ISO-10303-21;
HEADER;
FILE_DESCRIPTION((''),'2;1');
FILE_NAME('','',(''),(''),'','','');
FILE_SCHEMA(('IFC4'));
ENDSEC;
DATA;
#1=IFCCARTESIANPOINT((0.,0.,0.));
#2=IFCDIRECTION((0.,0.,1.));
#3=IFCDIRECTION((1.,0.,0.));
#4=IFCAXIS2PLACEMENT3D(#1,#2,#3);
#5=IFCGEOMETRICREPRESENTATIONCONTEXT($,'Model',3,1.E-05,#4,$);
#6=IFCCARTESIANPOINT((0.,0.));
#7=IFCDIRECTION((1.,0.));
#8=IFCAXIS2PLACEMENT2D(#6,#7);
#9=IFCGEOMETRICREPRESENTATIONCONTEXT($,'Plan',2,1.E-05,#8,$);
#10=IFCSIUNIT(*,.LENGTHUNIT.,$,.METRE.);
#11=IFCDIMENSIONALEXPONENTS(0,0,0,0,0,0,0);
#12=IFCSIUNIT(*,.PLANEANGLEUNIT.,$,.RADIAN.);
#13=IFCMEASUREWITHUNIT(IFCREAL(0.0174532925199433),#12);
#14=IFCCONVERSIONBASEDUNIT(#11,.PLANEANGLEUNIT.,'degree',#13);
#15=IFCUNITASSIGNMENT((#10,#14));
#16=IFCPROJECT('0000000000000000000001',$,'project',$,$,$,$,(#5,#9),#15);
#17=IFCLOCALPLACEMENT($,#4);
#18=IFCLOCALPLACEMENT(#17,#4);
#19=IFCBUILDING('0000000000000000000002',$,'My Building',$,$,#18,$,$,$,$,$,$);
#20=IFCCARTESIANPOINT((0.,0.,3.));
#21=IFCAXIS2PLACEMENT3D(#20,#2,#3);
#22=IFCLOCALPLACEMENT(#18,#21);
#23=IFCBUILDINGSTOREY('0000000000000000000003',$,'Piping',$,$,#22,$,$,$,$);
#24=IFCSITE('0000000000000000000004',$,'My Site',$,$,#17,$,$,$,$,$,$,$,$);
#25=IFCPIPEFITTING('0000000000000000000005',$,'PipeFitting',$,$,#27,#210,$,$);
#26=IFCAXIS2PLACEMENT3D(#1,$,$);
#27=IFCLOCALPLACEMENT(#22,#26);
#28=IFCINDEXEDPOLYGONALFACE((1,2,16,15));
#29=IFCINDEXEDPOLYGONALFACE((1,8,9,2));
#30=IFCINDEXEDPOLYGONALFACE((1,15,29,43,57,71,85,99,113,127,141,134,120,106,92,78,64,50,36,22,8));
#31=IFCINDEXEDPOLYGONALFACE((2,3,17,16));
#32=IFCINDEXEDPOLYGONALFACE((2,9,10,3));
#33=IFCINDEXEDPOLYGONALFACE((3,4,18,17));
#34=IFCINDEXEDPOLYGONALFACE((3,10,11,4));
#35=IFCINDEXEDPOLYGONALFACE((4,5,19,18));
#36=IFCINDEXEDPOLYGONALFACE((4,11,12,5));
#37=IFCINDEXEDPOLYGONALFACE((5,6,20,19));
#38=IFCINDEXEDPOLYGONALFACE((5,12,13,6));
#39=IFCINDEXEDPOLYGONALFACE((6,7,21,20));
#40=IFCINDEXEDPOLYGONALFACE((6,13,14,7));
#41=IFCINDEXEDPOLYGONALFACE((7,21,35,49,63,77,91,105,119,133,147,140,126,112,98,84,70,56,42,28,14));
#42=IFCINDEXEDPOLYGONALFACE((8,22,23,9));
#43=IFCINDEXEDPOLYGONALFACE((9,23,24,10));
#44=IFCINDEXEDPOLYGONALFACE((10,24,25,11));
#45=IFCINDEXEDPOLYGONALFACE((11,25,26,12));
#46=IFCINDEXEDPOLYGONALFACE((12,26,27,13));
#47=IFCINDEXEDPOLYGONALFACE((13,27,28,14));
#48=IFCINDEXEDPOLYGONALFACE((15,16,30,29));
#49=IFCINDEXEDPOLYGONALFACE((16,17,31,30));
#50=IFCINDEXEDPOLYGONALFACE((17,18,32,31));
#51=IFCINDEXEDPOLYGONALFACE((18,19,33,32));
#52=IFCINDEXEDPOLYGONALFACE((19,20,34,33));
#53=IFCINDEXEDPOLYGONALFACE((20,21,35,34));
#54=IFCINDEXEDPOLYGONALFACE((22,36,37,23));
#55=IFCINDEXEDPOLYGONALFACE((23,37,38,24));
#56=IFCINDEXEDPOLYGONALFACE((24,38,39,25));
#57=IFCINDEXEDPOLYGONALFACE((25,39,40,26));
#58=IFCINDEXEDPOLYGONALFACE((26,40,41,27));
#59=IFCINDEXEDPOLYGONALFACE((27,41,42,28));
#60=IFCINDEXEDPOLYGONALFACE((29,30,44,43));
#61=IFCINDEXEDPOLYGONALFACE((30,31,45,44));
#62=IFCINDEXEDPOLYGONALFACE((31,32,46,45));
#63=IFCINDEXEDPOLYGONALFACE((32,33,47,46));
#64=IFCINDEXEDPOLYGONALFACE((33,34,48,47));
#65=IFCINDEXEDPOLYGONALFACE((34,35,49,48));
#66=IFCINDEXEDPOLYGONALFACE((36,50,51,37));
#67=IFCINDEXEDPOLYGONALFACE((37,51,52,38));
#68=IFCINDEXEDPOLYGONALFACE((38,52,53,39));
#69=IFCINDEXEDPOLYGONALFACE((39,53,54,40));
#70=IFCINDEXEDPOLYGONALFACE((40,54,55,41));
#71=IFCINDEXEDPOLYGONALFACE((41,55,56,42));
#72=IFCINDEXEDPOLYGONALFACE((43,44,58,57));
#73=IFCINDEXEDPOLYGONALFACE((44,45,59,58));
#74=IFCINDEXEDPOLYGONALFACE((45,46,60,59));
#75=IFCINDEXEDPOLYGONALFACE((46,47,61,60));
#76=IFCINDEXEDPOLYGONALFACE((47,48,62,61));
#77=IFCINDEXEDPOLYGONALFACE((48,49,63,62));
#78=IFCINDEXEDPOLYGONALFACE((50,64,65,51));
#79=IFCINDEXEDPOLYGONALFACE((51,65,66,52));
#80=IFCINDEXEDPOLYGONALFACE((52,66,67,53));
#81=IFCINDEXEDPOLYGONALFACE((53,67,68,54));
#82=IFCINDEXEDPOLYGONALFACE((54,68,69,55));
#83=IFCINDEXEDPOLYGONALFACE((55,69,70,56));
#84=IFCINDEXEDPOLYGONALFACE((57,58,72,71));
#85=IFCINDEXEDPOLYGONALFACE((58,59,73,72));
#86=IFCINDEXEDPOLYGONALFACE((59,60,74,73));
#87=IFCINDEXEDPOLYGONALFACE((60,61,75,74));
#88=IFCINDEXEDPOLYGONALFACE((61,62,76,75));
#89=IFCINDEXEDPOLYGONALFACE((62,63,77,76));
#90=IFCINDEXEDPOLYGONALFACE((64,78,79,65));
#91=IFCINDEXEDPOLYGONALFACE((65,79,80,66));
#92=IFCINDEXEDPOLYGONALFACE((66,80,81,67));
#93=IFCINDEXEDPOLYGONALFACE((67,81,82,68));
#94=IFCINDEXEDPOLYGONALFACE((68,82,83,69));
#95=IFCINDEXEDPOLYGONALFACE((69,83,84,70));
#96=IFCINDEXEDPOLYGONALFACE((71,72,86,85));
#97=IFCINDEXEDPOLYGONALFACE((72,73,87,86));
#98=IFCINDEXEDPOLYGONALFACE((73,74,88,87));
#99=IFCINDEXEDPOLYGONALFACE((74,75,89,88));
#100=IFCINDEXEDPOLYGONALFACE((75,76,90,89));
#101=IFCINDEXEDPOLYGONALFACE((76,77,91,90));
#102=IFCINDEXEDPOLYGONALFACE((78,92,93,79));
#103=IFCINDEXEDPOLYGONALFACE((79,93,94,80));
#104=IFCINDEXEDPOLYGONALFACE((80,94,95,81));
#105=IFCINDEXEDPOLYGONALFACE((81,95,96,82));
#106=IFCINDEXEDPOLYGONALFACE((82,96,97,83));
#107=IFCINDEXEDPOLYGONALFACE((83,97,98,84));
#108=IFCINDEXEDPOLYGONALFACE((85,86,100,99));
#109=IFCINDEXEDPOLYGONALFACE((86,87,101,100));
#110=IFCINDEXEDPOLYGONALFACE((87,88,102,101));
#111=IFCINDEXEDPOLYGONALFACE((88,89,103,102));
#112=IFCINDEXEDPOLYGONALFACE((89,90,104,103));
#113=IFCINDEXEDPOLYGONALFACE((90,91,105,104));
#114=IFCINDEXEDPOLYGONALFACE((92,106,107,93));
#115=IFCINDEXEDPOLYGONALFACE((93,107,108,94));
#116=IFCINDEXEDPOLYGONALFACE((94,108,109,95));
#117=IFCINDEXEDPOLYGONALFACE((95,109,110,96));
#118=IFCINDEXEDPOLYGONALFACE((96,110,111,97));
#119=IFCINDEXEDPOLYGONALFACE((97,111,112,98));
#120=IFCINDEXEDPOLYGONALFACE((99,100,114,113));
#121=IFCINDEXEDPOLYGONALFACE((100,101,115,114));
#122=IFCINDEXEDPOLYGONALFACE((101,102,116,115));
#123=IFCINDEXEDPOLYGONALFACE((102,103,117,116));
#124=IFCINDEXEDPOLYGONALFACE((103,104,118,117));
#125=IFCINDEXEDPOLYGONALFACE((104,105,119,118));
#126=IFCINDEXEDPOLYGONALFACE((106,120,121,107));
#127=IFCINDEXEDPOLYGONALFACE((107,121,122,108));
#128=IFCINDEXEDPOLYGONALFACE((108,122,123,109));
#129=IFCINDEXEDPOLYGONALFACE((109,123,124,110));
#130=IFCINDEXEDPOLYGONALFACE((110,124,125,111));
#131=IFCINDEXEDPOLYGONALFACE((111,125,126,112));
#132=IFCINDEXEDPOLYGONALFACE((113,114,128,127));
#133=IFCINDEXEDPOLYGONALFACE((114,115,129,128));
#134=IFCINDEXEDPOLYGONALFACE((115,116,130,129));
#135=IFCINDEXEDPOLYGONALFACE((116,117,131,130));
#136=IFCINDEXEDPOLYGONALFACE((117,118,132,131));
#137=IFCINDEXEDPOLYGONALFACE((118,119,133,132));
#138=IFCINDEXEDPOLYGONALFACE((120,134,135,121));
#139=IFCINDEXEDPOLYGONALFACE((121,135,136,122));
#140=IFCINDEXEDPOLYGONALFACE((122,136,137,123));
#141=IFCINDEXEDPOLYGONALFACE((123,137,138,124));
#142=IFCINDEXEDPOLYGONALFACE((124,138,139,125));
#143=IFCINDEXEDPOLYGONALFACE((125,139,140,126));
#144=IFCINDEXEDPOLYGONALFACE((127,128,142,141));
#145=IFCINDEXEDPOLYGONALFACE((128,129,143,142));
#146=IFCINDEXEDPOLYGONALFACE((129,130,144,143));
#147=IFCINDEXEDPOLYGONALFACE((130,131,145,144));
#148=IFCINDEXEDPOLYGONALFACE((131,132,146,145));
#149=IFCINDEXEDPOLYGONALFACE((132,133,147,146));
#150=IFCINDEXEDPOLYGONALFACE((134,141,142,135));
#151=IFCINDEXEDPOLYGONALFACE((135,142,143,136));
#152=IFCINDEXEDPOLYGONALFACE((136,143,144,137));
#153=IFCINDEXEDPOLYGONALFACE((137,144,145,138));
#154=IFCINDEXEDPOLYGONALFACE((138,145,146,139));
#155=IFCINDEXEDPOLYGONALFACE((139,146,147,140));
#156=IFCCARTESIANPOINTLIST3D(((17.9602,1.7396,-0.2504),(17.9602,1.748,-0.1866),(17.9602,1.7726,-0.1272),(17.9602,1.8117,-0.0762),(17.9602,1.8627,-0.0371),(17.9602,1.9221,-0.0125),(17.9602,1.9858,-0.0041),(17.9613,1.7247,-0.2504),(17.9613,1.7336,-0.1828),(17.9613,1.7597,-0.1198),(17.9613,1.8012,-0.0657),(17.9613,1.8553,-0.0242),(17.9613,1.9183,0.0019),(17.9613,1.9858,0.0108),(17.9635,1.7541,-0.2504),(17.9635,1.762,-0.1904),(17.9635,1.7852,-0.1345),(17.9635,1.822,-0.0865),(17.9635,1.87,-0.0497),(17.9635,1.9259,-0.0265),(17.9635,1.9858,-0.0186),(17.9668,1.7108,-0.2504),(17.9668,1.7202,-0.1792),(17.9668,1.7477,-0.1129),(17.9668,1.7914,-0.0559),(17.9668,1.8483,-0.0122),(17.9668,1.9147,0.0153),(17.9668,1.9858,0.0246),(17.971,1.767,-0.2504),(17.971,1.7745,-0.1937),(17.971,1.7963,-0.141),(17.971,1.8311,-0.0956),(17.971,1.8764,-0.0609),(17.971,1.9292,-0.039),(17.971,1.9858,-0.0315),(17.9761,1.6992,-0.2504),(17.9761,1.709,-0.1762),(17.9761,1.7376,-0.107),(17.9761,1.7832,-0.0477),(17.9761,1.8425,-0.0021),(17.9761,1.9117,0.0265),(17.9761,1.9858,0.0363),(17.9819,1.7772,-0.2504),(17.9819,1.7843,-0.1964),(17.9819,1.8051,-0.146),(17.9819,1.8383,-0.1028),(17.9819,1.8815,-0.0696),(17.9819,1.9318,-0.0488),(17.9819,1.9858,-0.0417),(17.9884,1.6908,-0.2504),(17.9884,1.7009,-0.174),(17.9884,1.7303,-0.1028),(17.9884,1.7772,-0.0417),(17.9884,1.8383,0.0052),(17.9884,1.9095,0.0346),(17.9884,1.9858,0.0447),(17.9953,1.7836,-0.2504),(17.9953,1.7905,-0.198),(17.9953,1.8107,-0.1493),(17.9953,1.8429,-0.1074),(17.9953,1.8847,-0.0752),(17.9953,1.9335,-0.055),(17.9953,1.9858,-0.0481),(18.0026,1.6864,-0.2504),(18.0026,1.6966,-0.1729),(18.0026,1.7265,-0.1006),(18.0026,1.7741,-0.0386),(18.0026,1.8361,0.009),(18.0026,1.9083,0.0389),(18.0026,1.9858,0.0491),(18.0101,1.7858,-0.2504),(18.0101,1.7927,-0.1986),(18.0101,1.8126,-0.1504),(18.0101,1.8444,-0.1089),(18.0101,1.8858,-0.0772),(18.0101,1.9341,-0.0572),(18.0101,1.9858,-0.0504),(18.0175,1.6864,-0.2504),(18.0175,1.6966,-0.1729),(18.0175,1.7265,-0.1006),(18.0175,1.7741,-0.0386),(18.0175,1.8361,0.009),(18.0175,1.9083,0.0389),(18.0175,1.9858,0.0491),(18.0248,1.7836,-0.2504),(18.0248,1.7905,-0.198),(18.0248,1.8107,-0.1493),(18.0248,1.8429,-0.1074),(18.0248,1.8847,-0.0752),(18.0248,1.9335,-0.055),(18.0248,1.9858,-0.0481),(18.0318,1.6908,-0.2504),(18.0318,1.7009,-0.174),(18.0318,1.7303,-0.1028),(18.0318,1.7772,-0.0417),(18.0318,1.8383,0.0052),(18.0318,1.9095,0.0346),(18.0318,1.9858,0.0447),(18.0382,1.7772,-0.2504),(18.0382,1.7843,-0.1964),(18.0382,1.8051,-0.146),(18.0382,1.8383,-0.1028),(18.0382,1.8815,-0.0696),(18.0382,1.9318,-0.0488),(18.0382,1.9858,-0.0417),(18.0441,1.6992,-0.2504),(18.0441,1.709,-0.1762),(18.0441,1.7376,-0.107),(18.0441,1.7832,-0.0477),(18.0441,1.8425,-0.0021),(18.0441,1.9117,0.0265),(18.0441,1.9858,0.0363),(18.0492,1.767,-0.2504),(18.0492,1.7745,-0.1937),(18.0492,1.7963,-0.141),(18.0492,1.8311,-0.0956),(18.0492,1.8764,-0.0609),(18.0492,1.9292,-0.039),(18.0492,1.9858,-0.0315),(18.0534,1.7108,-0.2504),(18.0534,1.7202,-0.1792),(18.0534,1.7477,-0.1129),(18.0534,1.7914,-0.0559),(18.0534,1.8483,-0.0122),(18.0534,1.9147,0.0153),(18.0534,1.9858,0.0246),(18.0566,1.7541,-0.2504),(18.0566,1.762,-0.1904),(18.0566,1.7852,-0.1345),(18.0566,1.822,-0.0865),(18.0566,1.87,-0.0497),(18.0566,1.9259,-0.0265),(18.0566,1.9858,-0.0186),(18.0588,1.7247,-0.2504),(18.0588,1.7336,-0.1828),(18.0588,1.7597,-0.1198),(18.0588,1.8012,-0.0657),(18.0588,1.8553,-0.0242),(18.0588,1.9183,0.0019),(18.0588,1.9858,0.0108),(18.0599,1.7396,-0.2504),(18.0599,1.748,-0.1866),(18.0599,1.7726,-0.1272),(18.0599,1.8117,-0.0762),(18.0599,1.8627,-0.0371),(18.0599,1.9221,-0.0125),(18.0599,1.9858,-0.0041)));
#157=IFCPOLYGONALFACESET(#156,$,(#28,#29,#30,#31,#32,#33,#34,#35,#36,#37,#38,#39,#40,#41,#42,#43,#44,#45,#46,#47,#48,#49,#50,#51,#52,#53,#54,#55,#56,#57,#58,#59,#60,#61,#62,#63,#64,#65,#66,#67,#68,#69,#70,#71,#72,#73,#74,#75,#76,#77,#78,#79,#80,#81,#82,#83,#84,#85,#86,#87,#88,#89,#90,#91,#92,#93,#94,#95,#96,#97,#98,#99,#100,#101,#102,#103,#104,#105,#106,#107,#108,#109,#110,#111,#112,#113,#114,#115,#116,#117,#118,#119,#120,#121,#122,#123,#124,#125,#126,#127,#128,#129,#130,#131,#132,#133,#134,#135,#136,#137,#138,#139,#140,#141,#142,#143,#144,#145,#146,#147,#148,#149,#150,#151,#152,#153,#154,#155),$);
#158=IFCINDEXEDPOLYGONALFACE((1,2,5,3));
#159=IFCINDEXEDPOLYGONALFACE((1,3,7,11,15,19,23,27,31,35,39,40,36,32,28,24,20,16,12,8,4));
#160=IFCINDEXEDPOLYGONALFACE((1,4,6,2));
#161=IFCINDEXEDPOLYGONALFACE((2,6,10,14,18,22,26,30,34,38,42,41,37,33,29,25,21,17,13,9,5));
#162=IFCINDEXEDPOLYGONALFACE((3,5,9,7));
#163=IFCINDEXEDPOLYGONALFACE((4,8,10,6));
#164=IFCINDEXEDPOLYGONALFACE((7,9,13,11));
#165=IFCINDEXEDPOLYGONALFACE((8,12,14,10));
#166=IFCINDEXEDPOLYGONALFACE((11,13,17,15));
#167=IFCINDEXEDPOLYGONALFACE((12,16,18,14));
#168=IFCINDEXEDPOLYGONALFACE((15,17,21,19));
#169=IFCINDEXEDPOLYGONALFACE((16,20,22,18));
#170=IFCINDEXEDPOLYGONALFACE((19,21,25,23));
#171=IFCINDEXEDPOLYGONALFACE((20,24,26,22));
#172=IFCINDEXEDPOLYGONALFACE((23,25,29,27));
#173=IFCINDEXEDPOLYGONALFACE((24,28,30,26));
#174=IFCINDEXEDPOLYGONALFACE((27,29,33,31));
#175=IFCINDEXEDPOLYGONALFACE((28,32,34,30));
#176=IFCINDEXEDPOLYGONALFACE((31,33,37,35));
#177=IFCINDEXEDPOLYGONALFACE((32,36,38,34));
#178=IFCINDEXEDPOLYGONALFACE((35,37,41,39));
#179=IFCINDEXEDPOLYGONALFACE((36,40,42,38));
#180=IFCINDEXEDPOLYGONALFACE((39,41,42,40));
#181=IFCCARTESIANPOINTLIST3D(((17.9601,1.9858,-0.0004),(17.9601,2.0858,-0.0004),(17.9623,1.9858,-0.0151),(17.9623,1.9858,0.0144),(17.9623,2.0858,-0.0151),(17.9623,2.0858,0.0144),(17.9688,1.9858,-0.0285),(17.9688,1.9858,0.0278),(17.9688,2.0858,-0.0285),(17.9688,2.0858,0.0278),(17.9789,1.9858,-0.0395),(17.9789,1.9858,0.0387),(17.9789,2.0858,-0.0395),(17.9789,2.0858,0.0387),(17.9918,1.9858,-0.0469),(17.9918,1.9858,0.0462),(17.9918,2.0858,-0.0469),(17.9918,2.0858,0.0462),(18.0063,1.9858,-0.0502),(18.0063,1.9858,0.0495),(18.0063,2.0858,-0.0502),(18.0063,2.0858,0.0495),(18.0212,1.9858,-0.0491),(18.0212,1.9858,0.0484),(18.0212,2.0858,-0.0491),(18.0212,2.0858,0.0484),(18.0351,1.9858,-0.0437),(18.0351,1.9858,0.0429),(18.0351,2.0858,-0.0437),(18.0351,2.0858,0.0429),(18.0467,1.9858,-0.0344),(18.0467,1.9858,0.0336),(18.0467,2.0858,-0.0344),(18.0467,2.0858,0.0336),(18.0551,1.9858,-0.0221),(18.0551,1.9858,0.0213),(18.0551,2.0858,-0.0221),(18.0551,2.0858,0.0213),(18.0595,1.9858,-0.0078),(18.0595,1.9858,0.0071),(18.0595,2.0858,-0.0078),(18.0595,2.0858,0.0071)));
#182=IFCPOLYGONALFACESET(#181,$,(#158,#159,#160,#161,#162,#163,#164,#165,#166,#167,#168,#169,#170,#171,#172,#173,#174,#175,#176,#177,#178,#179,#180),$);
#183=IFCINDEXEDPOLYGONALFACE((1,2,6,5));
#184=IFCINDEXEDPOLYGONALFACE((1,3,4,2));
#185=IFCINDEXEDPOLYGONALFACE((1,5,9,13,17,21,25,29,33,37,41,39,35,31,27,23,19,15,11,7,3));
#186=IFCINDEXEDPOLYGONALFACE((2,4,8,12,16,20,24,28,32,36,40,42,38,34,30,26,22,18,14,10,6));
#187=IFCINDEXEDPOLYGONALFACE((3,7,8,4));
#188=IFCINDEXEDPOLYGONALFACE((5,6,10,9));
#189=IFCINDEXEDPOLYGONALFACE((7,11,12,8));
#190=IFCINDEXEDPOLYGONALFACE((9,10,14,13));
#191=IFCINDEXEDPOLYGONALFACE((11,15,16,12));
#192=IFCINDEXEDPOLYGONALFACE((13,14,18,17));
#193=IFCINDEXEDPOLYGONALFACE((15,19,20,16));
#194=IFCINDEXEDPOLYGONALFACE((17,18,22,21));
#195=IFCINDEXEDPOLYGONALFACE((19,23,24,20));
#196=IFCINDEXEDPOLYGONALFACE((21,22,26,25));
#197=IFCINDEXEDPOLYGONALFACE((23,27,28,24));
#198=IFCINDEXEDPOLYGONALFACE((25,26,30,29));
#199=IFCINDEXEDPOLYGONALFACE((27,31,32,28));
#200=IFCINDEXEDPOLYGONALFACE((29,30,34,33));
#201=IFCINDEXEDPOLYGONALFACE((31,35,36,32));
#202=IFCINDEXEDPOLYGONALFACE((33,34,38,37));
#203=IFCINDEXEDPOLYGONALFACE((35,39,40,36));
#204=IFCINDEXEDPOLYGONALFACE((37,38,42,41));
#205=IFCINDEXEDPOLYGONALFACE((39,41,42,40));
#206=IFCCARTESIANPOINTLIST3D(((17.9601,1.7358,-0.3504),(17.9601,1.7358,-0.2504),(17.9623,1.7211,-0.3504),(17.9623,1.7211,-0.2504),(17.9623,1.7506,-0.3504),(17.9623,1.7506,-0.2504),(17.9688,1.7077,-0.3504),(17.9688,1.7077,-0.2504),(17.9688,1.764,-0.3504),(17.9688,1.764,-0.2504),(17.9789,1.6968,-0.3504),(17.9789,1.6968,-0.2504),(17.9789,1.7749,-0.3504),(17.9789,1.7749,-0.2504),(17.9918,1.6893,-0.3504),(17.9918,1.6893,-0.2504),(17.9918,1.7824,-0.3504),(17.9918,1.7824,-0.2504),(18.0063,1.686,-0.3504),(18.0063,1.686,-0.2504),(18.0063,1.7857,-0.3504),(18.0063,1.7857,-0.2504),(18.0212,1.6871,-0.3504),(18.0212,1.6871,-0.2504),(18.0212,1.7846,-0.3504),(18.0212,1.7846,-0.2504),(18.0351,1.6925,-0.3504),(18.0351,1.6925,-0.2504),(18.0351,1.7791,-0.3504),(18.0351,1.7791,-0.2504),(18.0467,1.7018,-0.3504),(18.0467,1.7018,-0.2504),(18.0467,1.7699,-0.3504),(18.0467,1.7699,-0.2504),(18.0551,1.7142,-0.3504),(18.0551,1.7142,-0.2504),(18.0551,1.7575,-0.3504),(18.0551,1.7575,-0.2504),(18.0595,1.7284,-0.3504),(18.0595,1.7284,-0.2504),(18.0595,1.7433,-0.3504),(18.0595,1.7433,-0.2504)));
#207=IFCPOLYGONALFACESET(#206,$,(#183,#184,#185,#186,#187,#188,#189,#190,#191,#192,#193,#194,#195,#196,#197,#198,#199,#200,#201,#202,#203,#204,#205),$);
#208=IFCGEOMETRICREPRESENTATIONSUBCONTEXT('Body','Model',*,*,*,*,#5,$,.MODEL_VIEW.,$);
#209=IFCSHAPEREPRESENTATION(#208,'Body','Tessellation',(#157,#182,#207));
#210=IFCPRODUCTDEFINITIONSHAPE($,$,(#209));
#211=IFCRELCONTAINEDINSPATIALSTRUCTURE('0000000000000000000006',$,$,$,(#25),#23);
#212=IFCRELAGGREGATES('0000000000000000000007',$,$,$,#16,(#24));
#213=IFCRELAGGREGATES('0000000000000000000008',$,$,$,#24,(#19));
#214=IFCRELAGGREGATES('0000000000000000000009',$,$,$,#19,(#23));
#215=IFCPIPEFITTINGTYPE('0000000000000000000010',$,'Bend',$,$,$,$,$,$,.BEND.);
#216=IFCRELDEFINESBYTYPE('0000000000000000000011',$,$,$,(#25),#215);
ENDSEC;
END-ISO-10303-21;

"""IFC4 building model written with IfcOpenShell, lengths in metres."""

from ifc_helpers import new_model, entity, si_unit, converted_unit, frame, origin_with_axes, origin_2d_with_axis, place, context, subcontext, project, spatial, circle, extrude, source, transform, mapped, type_object, type_shapes, element, save


model = new_model("IFC4")

# Units and contexts
model_context = context("Model", 3, precision=1e-05, world=origin_with_axes())
plan_context = context("Plan", 2, precision=1e-05, world=origin_2d_with_axis())
body_context = subcontext(model_context, "Body", "Model", "MODEL_VIEW")
ifc_project = project(units=[si_unit("LENGTHUNIT", "METRE"), converted_unit("PLANEANGLEUNIT", "degree", entity("IfcReal", 0.0174532925199433), si_unit("PLANEANGLEUNIT", "RADIAN"), dimensions=[0, 0, 0, 0, 0, 0, 0])], contexts=[model_context, plan_context])

# Site, building, storey
site_placement = place(None, origin_with_axes())
site = spatial("IfcSite", under=ifc_project, at=site_placement, Name="My Site")
building_placement = place(site_placement, origin_with_axes())
building = spatial("IfcBuilding", under=site, at=building_placement, Name="My Building")
storey_placement = place(building_placement, frame((0.0, 0.0, 3.0), z_axis=(0.0, 0.0, 1.0), x_axis=(1.0, 0.0, 0.0)))
storey = spatial("IfcBuildingStorey", under=building, at=storey_placement, Name="Piping")

# Shared definitions
pipe_fitting_type = type_object("IfcPipeFittingType", Name="Bend", PredefinedType="BEND")
shared_shape = source(origin_with_axes(), body_context, "Body", "SolidModel", [
    entity("IfcSweptDiskSolid", entity("IfcIndexedPolyCurve", entity("IfcCartesianPointList3D", [[0.0, 0.0, -0.1], [0.0, -0.0732, -0.2768], [0.0, -0.25, -0.35]]), [entity("IfcArcIndex", [1, 2, 3])]), 0.05),
    extrude(circle(Radius=0.05), origin_with_axes(), (0.0, 0.0, -1.0), 0.1),
    extrude(circle(Radius=0.05), frame((0.0, -0.25, -0.35), z_axis=(0.0, -1.0, 0.0), x_axis=(1.0, 0.0, 0.0)), (0.0, 0.0, 1.0), 0.1),
])
type_shapes(pipe_fitting_type, [shared_shape])

# Pipe fitting
for number, where, z_axis, x_axis, name in (
    (1, (18.0101, 2.0858, -0.0004), (0.0, 1.0, 0.0), (-1.0, 0.0, 0.0), "PipeFitting"),
):
    element("IfcPipeFitting", number, at=place(storey_placement, frame(where, z_axis=z_axis, x_axis=x_axis)), inside=storey, type_object=pipe_fitting_type, Name=name, context=body_context, shape_type="MappedRepresentation", body=[
        mapped(shared_shape, transform((0.0, 0.0, 0.0), x_axis=(1.0, 0.0, 0.0), y_axis=(0.0, 1.0, 0.0), z_axis=(0.0, 0.0, 1.0), scale=1.0)),
    ])

save(model, "model.ifc")
